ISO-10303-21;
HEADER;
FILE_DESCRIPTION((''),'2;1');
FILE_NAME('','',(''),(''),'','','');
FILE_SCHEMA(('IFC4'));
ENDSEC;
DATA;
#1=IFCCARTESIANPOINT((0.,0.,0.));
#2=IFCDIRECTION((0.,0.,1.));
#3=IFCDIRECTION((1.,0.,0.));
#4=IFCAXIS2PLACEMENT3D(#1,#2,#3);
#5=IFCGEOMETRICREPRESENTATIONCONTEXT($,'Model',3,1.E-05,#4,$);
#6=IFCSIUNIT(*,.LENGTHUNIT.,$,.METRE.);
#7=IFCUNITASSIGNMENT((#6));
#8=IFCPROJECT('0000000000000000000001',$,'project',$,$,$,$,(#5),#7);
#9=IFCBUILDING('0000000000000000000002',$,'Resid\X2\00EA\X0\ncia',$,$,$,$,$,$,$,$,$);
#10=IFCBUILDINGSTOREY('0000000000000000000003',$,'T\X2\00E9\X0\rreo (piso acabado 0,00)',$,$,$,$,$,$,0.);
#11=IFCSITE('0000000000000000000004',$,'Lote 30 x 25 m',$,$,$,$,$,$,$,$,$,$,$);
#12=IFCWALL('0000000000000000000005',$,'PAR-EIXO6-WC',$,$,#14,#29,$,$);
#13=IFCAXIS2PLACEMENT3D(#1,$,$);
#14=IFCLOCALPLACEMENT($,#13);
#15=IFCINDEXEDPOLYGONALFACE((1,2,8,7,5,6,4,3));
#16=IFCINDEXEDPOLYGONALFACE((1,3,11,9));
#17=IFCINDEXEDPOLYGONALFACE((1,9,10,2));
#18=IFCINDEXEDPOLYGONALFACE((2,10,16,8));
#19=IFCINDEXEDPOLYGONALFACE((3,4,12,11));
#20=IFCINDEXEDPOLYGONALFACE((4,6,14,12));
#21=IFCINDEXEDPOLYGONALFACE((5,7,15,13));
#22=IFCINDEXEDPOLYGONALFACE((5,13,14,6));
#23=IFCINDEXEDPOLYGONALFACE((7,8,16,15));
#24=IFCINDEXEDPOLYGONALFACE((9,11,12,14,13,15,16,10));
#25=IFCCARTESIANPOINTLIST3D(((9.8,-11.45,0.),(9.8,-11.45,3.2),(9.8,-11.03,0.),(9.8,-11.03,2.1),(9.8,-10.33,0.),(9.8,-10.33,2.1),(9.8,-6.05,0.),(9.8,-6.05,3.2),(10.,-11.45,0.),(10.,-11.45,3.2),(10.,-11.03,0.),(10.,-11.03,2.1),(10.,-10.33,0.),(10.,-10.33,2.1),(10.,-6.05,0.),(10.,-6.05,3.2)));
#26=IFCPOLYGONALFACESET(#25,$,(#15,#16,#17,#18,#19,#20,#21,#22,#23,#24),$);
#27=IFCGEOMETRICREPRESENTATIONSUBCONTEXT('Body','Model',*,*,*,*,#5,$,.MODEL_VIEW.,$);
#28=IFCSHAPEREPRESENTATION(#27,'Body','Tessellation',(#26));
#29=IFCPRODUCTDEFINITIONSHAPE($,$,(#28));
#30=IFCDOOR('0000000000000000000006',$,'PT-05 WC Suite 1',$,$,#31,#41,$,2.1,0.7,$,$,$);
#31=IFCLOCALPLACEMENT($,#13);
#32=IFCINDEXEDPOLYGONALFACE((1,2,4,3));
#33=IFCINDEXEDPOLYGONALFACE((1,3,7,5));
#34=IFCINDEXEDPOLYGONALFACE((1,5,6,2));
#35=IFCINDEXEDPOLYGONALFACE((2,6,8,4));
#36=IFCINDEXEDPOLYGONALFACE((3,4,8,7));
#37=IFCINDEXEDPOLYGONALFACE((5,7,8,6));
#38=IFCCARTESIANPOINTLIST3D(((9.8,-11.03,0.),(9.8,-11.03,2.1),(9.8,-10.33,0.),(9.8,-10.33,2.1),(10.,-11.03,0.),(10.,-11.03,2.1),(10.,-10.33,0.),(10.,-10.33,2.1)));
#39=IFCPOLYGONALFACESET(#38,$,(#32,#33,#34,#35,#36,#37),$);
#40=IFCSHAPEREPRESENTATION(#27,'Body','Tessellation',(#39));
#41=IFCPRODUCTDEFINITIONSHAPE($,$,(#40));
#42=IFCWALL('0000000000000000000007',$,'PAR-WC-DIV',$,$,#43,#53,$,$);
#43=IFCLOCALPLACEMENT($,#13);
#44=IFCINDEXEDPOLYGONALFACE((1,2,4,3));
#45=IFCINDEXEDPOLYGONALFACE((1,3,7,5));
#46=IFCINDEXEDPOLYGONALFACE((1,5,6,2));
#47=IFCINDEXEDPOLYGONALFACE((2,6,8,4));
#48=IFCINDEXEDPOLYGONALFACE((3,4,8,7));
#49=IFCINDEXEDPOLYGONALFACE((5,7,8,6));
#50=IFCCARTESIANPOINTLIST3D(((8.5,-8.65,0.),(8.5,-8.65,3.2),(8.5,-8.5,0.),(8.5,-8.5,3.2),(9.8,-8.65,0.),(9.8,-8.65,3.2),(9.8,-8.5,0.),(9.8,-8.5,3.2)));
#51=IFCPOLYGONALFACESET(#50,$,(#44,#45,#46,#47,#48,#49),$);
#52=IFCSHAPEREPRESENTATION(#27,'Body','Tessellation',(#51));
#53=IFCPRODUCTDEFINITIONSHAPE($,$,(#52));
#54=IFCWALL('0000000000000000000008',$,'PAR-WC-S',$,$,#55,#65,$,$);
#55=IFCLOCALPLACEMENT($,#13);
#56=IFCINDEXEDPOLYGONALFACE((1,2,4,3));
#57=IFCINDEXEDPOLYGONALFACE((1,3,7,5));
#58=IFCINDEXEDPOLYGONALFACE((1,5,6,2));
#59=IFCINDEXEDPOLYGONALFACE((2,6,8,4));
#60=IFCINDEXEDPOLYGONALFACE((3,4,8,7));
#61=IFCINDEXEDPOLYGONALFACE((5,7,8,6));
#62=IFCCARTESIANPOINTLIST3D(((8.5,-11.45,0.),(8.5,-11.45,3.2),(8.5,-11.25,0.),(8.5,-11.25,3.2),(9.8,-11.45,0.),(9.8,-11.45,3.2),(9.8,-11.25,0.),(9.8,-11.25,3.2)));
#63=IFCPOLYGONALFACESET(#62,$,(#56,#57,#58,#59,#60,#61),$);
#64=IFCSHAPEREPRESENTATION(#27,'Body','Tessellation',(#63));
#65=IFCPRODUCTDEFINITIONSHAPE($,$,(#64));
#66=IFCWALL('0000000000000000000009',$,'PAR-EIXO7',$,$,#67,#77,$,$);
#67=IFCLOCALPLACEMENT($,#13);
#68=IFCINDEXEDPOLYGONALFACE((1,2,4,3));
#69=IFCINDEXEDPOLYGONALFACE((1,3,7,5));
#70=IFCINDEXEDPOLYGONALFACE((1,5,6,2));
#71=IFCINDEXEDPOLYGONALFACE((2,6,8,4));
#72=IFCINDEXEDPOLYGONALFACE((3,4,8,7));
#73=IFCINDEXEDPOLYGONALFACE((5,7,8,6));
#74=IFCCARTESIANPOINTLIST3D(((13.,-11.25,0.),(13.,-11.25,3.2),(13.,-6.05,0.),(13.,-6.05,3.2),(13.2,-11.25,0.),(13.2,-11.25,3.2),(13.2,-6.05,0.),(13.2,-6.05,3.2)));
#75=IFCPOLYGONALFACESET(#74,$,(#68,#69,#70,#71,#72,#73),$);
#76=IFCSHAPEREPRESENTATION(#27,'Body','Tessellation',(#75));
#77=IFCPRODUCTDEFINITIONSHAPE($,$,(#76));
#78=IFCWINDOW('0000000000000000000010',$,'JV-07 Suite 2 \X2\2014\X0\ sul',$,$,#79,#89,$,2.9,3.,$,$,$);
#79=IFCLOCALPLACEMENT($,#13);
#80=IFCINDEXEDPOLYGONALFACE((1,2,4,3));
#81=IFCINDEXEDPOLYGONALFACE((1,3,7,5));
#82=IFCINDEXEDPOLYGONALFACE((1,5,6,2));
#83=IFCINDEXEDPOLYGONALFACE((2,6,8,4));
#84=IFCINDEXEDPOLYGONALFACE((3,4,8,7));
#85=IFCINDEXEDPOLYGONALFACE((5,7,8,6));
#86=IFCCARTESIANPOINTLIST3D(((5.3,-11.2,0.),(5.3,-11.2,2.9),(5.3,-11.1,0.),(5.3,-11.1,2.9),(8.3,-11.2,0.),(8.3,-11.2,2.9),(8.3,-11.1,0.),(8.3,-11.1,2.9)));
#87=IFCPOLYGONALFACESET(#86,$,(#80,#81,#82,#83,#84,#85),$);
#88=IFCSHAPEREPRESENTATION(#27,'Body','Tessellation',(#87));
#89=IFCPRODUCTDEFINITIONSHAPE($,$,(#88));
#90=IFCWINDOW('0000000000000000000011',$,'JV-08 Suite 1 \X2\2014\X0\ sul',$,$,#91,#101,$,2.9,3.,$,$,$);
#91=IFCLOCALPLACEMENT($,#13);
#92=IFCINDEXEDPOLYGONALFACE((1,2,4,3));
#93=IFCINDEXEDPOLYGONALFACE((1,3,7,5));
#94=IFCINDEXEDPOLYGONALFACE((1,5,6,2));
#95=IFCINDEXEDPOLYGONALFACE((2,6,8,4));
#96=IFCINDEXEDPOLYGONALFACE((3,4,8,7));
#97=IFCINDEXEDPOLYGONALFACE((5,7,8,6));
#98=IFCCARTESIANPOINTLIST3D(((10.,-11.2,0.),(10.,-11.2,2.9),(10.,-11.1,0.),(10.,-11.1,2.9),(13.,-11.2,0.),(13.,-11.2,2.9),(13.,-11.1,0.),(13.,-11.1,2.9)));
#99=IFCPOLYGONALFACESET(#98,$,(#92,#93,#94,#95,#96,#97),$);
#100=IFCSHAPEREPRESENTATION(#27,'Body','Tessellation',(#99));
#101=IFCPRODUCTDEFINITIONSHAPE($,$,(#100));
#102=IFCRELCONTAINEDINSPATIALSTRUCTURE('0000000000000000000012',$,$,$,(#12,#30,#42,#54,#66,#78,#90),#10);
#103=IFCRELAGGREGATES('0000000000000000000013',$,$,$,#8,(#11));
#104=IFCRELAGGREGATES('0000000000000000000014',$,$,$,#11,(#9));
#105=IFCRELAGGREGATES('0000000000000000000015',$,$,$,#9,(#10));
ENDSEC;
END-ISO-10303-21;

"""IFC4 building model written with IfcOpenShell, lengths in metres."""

from ifc_helpers import new_model, si_unit, frame, origin_with_axes, place, context, subcontext, project, spatial, line, indexed_curve, outline, extrude, element, fill, save


model = new_model("IFC4")

# Units and contexts
model_context = context("Model", 3, precision=1e-05, world=origin_with_axes())
body_context = subcontext(model_context, "Body", "Model", "MODEL_VIEW")
ifc_project = project(units=[si_unit("LENGTHUNIT", "METRE")], contexts=[model_context])

# Site, building, storey
site = spatial("IfcSite", under=ifc_project, Name="Lote 30 x 25 m")
building = spatial("IfcBuilding", under=site, Name="Residência")
storey = spatial("IfcBuildingStorey", under=building, Name="Térreo (piso acabado 0,00)", Elevation=0.0)

# Wall, opening, door
wall_1_placement = place(None, frame((9.8, -11.45, 0.0), z_axis=(0.0, 0.0, 1.0), x_axis=(1.0, 0.0, 0.0)))
wall_1 = element("IfcWall", 1, at=wall_1_placement, inside=storey, Name="PAR-EIXO6-WC", context=body_context, shape_type="SweptSolid", body=[
    extrude(outline(indexed_curve([(0.0, 0.0), (0.2, 0.0), (0.2, 5.4), (0.0, 5.4)], segments=[line(1, 2, 3, 4, 1)])), origin_with_axes(), (0.0, 0.0, 1.0), 3.2),
])
opening_1_placement = place(wall_1_placement, frame((0.0, 0.42, 0.0), z_axis=(0.0, 0.0, 1.0), x_axis=(1.0, 0.0, 0.0)))
opening_1 = element("IfcOpeningElement", 2, at=opening_1_placement, cuts=wall_1, context=body_context, shape_type="SweptSolid", body=[
    extrude(outline(indexed_curve([(0.0, 0.0), (0.2, 0.0), (0.2, 0.7), (0.0, 0.7)], segments=[line(1, 2, 3, 4, 1)])), origin_with_axes(), (0.0, 0.0, 1.0), 2.1),
])
door_1_placement = place(None, frame((9.8, -11.03, 0.0), z_axis=(0.0, 0.0, 1.0), x_axis=(1.0, 0.0, 0.0)))
door_1 = element("IfcDoor", 3, at=door_1_placement, inside=storey, Name="PT-05 WC Suite 1", OverallHeight=2.1, OverallWidth=0.7, context=body_context, shape_type="SweptSolid", body=[
    extrude(outline(indexed_curve([(0.0, 0.0), (0.2, 0.0), (0.2, 0.7), (0.0, 0.7)], segments=[line(1, 2, 3, 4, 1)])), origin_with_axes(), (0.0, 0.0, 1.0), 2.1),
])
fill(opening_1, door_1)

# Walls
wall_2_placement = place(None, frame((8.5, -8.65, 0.0), z_axis=(0.0, 0.0, 1.0), x_axis=(1.0, 0.0, 0.0)))
element("IfcWall", 4, at=wall_2_placement, inside=storey, Name="PAR-WC-DIV", context=body_context, shape_type="SweptSolid", body=[
    extrude(outline(indexed_curve([(0.0, 0.0), (1.3, 0.0), (1.3, 0.15), (0.0, 0.15)], segments=[line(1, 2, 3, 4, 1)])), origin_with_axes(), (0.0, 0.0, 1.0), 3.2),
])
wall_3_placement = place(None, frame((8.5, -11.45, 0.0), z_axis=(0.0, 0.0, 1.0), x_axis=(1.0, 0.0, 0.0)))
element("IfcWall", 5, at=wall_3_placement, inside=storey, Name="PAR-WC-S", context=body_context, shape_type="SweptSolid", body=[
    extrude(outline(indexed_curve([(0.0, 0.0), (1.3, 0.0), (1.3, 0.2), (0.0, 0.2)], segments=[line(1, 2, 3, 4, 1)])), origin_with_axes(), (0.0, 0.0, 1.0), 3.2),
])
wall_4_placement = place(None, frame((13.0, -11.25, 0.0), z_axis=(0.0, 0.0, 1.0), x_axis=(1.0, 0.0, 0.0)))
element("IfcWall", 6, at=wall_4_placement, inside=storey, Name="PAR-EIXO7", context=body_context, shape_type="SweptSolid", body=[
    extrude(outline(indexed_curve([(0.0, 0.0), (0.2, 0.0), (0.2, 5.2), (0.0, 5.2)], segments=[line(1, 2, 3, 4, 1)])), origin_with_axes(), (0.0, 0.0, 1.0), 3.2),
])

# Windows
for number, where, z_axis, x_axis, name in (
    (7, (5.3, -11.2, 0.0), (0.0, 0.0, 1.0), (1.0, 0.0, 0.0), "JV-07 Suite 2 — sul"),
    (8, (10.0, -11.2, 0.0), (0.0, 0.0, 1.0), (1.0, 0.0, 0.0), "JV-08 Suite 1 — sul"),
):
    element("IfcWindow", number, at=place(None, frame(where, z_axis=z_axis, x_axis=x_axis)), inside=storey, Name=name, OverallHeight=2.9, OverallWidth=3.0, context=body_context, shape_type="SweptSolid", body=[
        extrude(outline(indexed_curve([(0.0, 0.0), (3.0, 0.0), (3.0, 0.1), (0.0, 0.1)], segments=[line(1, 2, 3, 4, 1)])), origin_with_axes(), (0.0, 0.0, 1.0), 2.9),
    ])

save(model, "model.ifc")
